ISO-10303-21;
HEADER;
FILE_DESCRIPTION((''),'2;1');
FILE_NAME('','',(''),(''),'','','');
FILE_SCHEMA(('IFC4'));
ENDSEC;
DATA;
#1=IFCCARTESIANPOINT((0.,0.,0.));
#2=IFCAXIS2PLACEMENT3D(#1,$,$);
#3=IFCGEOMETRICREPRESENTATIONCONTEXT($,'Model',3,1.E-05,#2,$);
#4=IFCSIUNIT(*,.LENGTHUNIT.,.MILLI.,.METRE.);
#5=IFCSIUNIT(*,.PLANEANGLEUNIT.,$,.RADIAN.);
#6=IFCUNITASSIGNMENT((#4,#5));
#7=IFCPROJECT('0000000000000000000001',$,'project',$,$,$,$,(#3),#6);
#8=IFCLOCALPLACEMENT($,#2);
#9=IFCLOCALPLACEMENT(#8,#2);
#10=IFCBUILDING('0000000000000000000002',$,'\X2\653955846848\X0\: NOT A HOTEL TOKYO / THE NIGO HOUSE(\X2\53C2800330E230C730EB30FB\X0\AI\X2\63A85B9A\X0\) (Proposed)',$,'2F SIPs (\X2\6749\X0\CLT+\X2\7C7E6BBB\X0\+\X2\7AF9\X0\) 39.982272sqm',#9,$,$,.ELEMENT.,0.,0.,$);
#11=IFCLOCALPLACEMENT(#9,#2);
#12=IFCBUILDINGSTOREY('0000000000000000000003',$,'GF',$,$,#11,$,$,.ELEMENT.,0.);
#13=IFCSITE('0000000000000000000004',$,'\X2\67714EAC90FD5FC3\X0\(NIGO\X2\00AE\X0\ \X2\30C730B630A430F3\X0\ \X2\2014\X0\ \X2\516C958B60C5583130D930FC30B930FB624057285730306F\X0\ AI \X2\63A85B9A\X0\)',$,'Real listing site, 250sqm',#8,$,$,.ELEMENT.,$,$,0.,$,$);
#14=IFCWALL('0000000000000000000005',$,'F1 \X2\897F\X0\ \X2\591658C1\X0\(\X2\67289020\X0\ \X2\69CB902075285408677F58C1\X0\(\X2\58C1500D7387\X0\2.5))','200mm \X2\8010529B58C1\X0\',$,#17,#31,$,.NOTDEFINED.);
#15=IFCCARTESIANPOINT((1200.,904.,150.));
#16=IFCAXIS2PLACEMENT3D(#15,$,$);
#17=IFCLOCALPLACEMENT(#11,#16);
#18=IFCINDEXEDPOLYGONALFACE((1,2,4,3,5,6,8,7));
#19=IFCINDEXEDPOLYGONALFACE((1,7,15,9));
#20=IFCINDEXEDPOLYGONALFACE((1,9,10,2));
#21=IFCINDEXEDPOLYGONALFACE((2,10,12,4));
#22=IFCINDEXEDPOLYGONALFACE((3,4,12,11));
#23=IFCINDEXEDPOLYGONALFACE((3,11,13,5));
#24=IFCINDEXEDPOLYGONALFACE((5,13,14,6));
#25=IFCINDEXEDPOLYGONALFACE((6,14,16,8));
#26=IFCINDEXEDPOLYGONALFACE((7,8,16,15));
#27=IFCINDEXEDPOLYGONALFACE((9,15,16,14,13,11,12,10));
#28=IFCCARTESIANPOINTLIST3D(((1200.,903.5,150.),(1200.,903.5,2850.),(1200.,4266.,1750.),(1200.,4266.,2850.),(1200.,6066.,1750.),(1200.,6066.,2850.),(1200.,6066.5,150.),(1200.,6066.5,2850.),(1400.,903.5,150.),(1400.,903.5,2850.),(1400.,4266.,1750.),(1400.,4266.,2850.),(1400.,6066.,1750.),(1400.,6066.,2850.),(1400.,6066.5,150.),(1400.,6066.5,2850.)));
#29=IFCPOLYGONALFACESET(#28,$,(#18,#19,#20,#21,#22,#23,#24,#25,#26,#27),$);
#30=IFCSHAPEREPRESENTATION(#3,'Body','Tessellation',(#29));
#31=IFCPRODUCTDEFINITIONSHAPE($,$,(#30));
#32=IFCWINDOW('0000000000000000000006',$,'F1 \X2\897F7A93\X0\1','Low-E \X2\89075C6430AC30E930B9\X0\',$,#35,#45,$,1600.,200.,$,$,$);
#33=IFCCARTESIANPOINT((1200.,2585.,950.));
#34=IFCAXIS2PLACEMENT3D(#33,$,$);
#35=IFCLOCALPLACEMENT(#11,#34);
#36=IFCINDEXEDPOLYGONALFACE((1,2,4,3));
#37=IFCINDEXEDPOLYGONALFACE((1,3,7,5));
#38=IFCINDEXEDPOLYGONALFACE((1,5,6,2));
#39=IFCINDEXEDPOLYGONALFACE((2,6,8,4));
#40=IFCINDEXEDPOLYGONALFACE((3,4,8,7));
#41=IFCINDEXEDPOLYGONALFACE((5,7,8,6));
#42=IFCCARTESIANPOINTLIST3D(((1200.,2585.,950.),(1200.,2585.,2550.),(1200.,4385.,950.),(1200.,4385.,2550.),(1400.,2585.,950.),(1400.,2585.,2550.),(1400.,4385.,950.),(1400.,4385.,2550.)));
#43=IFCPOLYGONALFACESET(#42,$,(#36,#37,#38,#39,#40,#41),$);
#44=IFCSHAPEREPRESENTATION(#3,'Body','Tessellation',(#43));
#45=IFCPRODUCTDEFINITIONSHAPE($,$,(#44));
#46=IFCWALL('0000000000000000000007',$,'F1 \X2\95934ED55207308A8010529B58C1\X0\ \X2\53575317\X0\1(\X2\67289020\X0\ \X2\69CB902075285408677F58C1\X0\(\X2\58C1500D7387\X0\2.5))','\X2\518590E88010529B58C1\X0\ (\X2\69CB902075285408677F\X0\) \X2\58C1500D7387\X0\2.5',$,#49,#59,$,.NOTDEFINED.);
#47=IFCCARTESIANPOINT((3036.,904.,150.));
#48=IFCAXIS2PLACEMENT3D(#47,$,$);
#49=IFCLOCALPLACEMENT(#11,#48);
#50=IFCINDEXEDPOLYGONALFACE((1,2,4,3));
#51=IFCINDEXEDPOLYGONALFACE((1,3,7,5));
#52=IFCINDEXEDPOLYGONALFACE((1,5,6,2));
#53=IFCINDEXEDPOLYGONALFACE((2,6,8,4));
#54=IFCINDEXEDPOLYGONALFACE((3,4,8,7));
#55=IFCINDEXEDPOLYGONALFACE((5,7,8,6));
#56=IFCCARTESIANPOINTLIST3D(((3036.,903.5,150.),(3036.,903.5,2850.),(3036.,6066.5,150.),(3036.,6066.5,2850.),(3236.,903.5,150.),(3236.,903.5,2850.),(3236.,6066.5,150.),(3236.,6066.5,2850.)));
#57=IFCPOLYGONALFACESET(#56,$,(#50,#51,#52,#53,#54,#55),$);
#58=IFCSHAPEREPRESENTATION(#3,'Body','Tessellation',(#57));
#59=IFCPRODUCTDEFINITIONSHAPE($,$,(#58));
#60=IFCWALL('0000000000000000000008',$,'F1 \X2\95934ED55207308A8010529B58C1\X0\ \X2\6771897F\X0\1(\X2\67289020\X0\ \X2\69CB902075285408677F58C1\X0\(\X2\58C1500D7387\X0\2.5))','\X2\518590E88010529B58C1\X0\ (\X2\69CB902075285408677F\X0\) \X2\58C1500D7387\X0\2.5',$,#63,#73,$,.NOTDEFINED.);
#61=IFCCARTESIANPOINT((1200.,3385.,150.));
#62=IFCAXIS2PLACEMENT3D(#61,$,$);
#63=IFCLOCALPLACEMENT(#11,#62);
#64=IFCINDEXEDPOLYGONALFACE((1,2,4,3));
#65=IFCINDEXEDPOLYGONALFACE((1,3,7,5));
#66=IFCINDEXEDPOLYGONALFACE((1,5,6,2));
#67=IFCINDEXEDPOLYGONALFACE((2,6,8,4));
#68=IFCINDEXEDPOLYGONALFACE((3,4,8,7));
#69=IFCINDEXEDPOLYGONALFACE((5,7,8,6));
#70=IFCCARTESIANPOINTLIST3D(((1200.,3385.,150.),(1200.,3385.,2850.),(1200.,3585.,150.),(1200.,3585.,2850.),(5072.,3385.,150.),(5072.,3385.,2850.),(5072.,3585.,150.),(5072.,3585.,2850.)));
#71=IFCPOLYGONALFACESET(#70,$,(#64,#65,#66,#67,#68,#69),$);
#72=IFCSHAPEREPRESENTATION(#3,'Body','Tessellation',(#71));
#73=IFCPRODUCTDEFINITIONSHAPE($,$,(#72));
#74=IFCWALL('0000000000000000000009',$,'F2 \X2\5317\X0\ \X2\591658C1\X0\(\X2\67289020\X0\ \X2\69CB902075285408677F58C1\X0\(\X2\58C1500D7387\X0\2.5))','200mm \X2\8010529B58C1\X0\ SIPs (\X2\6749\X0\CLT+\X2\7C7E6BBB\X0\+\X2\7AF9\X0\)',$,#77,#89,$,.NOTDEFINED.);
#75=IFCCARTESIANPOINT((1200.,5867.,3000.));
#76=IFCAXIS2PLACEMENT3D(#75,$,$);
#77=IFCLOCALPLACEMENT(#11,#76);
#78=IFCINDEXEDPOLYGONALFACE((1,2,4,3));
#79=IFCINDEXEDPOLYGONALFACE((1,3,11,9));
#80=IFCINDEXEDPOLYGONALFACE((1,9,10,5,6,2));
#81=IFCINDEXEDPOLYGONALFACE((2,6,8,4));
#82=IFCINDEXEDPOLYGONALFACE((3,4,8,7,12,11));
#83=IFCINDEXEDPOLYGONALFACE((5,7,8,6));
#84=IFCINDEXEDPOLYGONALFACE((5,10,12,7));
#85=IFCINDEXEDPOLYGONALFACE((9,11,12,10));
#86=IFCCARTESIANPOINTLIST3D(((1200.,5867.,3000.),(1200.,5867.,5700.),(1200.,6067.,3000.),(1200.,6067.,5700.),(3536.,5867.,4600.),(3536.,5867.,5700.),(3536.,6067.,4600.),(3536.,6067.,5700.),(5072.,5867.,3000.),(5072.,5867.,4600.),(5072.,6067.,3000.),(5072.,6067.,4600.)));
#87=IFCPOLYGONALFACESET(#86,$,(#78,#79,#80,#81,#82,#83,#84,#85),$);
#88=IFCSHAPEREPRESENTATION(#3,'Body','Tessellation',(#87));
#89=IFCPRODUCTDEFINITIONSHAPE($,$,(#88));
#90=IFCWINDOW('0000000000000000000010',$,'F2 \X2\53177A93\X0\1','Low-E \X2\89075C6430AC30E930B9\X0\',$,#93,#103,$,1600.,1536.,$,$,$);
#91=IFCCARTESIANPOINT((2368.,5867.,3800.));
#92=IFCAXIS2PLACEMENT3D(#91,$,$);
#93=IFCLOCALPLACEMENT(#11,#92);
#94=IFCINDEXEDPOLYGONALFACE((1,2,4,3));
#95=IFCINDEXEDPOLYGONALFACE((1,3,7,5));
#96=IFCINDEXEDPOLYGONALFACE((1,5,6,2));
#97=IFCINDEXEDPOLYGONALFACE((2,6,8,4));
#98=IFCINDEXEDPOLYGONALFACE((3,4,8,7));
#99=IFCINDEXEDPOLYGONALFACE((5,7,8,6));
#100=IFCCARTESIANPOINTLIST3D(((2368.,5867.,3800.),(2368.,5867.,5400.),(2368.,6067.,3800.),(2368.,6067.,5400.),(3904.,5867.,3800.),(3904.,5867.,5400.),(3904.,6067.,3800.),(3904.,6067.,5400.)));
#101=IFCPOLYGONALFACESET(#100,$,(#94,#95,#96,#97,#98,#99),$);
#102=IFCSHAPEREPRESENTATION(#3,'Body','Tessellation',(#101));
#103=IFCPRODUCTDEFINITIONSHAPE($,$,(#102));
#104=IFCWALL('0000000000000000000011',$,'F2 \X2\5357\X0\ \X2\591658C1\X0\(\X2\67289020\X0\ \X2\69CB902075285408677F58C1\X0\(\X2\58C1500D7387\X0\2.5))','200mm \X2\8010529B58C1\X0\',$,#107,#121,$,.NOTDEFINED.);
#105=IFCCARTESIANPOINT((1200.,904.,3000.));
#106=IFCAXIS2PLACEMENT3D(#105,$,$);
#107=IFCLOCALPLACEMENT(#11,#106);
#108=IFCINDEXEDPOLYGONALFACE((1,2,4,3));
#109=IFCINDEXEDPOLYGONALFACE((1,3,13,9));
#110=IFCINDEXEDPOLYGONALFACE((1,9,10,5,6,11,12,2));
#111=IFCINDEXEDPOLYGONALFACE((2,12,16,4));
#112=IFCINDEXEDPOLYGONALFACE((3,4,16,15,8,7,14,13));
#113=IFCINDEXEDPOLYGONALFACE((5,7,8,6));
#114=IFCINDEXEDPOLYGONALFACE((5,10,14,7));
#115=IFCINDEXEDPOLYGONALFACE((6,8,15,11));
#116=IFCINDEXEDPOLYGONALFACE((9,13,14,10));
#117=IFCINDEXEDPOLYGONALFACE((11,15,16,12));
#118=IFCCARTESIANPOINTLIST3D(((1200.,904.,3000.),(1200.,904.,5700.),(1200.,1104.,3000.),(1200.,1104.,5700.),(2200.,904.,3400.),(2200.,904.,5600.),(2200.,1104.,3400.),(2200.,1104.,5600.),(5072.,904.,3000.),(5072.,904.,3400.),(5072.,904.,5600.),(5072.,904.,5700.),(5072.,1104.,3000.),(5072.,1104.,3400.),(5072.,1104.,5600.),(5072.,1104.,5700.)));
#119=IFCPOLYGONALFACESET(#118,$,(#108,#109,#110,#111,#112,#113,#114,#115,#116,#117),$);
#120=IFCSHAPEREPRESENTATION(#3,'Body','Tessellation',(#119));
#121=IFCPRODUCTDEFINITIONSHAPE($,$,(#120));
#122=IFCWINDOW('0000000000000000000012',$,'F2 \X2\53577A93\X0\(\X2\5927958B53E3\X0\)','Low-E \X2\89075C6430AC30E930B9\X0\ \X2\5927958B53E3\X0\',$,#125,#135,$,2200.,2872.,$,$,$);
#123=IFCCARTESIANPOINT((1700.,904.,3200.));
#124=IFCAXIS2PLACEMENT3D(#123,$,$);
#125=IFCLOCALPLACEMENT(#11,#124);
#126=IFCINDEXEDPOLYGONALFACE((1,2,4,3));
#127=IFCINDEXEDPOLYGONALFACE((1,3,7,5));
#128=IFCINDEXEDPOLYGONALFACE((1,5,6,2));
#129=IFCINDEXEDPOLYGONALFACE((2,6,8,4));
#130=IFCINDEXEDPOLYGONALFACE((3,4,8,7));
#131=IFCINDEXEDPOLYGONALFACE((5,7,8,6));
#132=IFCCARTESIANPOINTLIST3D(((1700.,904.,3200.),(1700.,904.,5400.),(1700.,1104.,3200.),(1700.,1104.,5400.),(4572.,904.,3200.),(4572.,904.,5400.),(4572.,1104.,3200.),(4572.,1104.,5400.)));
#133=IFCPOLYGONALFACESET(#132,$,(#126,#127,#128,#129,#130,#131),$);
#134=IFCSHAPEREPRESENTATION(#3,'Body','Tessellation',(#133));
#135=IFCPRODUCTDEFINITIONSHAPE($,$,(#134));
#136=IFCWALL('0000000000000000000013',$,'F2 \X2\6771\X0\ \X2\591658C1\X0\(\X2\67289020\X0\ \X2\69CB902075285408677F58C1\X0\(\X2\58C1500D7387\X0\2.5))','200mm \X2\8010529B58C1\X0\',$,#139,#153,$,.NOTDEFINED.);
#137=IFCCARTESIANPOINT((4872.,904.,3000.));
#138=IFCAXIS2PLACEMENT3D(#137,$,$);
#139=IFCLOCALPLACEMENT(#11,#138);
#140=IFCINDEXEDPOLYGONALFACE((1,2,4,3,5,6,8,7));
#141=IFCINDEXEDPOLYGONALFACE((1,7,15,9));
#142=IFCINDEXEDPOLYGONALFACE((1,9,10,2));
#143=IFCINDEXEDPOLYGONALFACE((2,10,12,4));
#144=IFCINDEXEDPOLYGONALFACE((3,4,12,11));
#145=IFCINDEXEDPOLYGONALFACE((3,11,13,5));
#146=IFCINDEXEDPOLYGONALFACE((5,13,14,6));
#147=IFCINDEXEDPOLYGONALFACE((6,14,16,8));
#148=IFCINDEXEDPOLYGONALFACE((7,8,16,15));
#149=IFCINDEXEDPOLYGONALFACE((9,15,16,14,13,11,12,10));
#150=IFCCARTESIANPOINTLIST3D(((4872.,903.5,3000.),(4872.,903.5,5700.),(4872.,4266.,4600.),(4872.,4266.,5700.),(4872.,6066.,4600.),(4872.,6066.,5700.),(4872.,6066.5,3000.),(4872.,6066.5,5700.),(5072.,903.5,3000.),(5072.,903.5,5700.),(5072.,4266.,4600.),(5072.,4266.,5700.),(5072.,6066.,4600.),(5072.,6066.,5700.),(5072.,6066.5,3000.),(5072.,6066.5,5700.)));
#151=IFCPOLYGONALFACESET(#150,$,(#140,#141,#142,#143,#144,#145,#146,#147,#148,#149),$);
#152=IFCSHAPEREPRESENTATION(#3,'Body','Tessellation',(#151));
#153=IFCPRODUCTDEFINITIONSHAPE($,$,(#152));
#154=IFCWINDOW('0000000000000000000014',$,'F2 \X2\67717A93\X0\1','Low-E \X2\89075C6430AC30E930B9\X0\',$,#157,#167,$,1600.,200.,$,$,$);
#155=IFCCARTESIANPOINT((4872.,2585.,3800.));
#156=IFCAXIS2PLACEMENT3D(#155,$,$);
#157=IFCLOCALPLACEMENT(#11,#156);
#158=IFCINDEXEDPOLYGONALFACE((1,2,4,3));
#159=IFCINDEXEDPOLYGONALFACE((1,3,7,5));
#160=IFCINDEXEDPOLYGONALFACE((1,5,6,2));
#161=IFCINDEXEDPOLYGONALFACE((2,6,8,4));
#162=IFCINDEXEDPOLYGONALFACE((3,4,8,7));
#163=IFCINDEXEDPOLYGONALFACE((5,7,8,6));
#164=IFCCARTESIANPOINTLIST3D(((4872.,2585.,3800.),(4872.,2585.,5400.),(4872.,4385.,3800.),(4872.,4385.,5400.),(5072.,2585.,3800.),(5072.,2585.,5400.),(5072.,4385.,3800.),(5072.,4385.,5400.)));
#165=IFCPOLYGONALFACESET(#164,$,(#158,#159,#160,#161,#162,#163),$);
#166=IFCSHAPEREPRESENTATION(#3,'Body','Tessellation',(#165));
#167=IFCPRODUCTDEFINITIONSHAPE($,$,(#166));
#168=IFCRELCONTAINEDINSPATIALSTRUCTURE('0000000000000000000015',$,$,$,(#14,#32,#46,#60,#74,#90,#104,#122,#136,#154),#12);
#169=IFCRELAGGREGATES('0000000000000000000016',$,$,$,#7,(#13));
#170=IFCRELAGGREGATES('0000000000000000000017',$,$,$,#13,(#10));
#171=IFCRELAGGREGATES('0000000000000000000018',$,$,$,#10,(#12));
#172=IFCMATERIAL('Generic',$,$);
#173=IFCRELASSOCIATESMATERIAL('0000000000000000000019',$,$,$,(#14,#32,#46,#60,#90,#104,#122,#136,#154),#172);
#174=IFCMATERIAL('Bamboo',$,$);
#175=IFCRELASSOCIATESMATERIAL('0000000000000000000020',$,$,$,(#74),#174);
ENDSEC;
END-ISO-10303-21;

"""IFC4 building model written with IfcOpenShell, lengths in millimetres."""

from ifc_helpers import new_model, si_unit, frame, frame_2d, origin, place, context, project, spatial, rectangle, extrude, material, element, fill, save


model = new_model("IFC4")

# Units and contexts
model_context = context("Model", 3, precision=1e-05, world=origin())
ifc_project = project(units=[si_unit("LENGTHUNIT", "METRE", prefix="MILLI"), si_unit("PLANEANGLEUNIT", "RADIAN")], contexts=[model_context])

# Site, building, storey
site_placement = place(None, origin())
site = spatial("IfcSite", under=ifc_project, at=site_placement, Name="東京都心(NIGO® デザイン — 公開情報ベース・所在地は AI 推定)", ObjectType="Real listing site, 250sqm", CompositionType="ELEMENT", RefElevation=0.0)
building_placement = place(site_placement, origin())
building = spatial("IfcBuilding", under=site, at=building_placement, Name="改善案: NOT A HOTEL TOKYO / THE NIGO HOUSE(参考モデル・AI推定) (Proposed)", ObjectType="2F SIPs (杉CLT+籾殻+竹) 39.982272sqm", CompositionType="ELEMENT", ElevationOfRefHeight=0.0, ElevationOfTerrain=0.0)
storey_placement = place(building_placement, origin())
storey = spatial("IfcBuildingStorey", under=building, at=storey_placement, Name="GF", CompositionType="ELEMENT", Elevation=0.0)

# Shared definitions
ifc_material_1 = material(Name="Generic")

# Shared definitions
ifc_material_2 = material(Name="Bamboo")

# Wall, opening, window
wall_1_placement = place(storey_placement, frame((1200.0, 904.0, 150.0)))
wall_1 = element("IfcWall", 1, at=wall_1_placement, inside=storey, material=ifc_material_1, Name="F1 西 外壁(木造 構造用合板壁(壁倍率2.5))", Description="200mm 耐力壁", PredefinedType="NOTDEFINED", context=model_context, shape_type="SweptSolid", body=[
    extrude(rectangle(XDim=200.0, YDim=5163.0, at=frame_2d((100.0, 2581.0))), frame((1200.0, 904.0, 150.0)), (0.0, 0.0, 1.0), 2700.0),
])
opening_1_placement = place(storey_placement, frame((1200.0, 2585.0, 950.0)))
opening_1 = element("IfcOpeningElement", 2, at=opening_1_placement, cuts=wall_1, PredefinedType="NOTDEFINED", context=model_context, shape_type="SweptSolid", body=[
    extrude(rectangle(XDim=200.0, YDim=1800.0, at=frame_2d((100.0, 900.0))), frame((1200.0, 2585.0, 950.0)), (0.0, 0.0, 1.0), 1600.0),
])
window_1_placement = place(storey_placement, frame((1200.0, 2585.0, 950.0)))
window_1 = element("IfcWindow", 3, at=window_1_placement, inside=storey, material=ifc_material_1, Name="F1 西窓1", Description="Low-E 複層ガラス", OverallHeight=1600.0, OverallWidth=200.0, context=model_context, shape_type="SweptSolid", body=[
    extrude(rectangle(XDim=200.0, YDim=1800.0, at=frame_2d((100.0, 900.0))), frame((1200.0, 2585.0, 950.0)), (0.0, 0.0, 1.0), 1600.0),
])
fill(opening_1, window_1)

# Walls
wall_2_placement = place(storey_placement, frame((3036.0, 904.0, 150.0)))
element("IfcWall", 4, at=wall_2_placement, inside=storey, material=ifc_material_1, Name="F1 間仕切り耐力壁 南北1(木造 構造用合板壁(壁倍率2.5))", Description="内部耐力壁 (構造用合板) 壁倍率2.5", PredefinedType="NOTDEFINED", context=model_context, shape_type="SweptSolid", body=[
    extrude(rectangle(XDim=200.0, YDim=5163.0, at=frame_2d((100.0, 2581.0))), frame((3036.0, 904.0, 150.0)), (0.0, 0.0, 1.0), 2700.0),
])
wall_3_placement = place(storey_placement, frame((1200.0, 3385.0, 150.0)))
element("IfcWall", 5, at=wall_3_placement, inside=storey, material=ifc_material_1, Name="F1 間仕切り耐力壁 東西1(木造 構造用合板壁(壁倍率2.5))", Description="内部耐力壁 (構造用合板) 壁倍率2.5", PredefinedType="NOTDEFINED", context=model_context, shape_type="SweptSolid", body=[
    extrude(rectangle(XDim=3872.0, YDim=200.0, at=frame_2d((1936.0, 100.0))), frame((1200.0, 3385.0, 150.0)), (0.0, 0.0, 1.0), 2700.0),
])

# Walls, openings, windows
wall_4_placement = place(storey_placement, frame((1200.0, 5867.0, 3000.0)))
wall_4 = element("IfcWall", 6, at=wall_4_placement, inside=storey, material=ifc_material_2, Name="F2 北 外壁(木造 構造用合板壁(壁倍率2.5))", Description="200mm 耐力壁 SIPs (杉CLT+籾殻+竹)", PredefinedType="NOTDEFINED", context=model_context, shape_type="SweptSolid", body=[
    extrude(rectangle(XDim=3872.0, YDim=200.0, at=frame_2d((1936.0, 100.0))), frame((1200.0, 5867.0, 3000.0)), (0.0, 0.0, 1.0), 2700.0),
])
opening_2_placement = place(storey_placement, frame((2368.0, 5867.0, 3800.0)))
opening_2 = element("IfcOpeningElement", 7, at=opening_2_placement, cuts=wall_4, PredefinedType="NOTDEFINED", context=model_context, shape_type="SweptSolid", body=[
    extrude(rectangle(XDim=1536.0, YDim=200.0, at=frame_2d((768.0, 100.0))), frame((2368.0, 5867.0, 3800.0)), (0.0, 0.0, 1.0), 1600.0),
])
window_2_placement = place(storey_placement, frame((2368.0, 5867.0, 3800.0)))
window_2 = element("IfcWindow", 8, at=window_2_placement, inside=storey, material=ifc_material_1, Name="F2 北窓1", Description="Low-E 複層ガラス", OverallHeight=1600.0, OverallWidth=1536.0, context=model_context, shape_type="SweptSolid", body=[
    extrude(rectangle(XDim=1536.0, YDim=200.0, at=frame_2d((768.0, 100.0))), frame((2368.0, 5867.0, 3800.0)), (0.0, 0.0, 1.0), 1600.0),
])
fill(opening_2, window_2)
wall_5_placement = place(storey_placement, frame((1200.0, 904.0, 3000.0)))
wall_5 = element("IfcWall", 9, at=wall_5_placement, inside=storey, material=ifc_material_1, Name="F2 南 外壁(木造 構造用合板壁(壁倍率2.5))", Description="200mm 耐力壁", PredefinedType="NOTDEFINED", context=model_context, shape_type="SweptSolid", body=[
    extrude(rectangle(XDim=3872.0, YDim=200.0, at=frame_2d((1936.0, 100.0))), frame((1200.0, 904.0, 3000.0)), (0.0, 0.0, 1.0), 2700.0),
])
opening_3_placement = place(storey_placement, frame((1700.0, 904.0, 3200.0)))
opening_3 = element("IfcOpeningElement", 10, at=opening_3_placement, cuts=wall_5, PredefinedType="NOTDEFINED", context=model_context, shape_type="SweptSolid", body=[
    extrude(rectangle(XDim=2872.0, YDim=200.0, at=frame_2d((1436.0, 100.0))), frame((1700.0, 904.0, 3200.0)), (0.0, 0.0, 1.0), 2200.0),
])
window_3_placement = place(storey_placement, frame((1700.0, 904.0, 3200.0)))
window_3 = element("IfcWindow", 11, at=window_3_placement, inside=storey, material=ifc_material_1, Name="F2 南窓(大開口)", Description="Low-E 複層ガラス 大開口", OverallHeight=2200.0, OverallWidth=2872.0, context=model_context, shape_type="SweptSolid", body=[
    extrude(rectangle(XDim=2872.0, YDim=200.0, at=frame_2d((1436.0, 100.0))), frame((1700.0, 904.0, 3200.0)), (0.0, 0.0, 1.0), 2200.0),
])
fill(opening_3, window_3)
wall_6_placement = place(storey_placement, frame((4872.0, 904.0, 3000.0)))
wall_6 = element("IfcWall", 12, at=wall_6_placement, inside=storey, material=ifc_material_1, Name="F2 東 外壁(木造 構造用合板壁(壁倍率2.5))", Description="200mm 耐力壁", PredefinedType="NOTDEFINED", context=model_context, shape_type="SweptSolid", body=[
    extrude(rectangle(XDim=200.0, YDim=5163.0, at=frame_2d((100.0, 2581.0))), frame((4872.0, 904.0, 3000.0)), (0.0, 0.0, 1.0), 2700.0),
])
opening_4_placement = place(storey_placement, frame((4872.0, 2585.0, 3800.0)))
opening_4 = element("IfcOpeningElement", 13, at=opening_4_placement, cuts=wall_6, PredefinedType="NOTDEFINED", context=model_context, shape_type="SweptSolid", body=[
    extrude(rectangle(XDim=200.0, YDim=1800.0, at=frame_2d((100.0, 900.0))), frame((4872.0, 2585.0, 3800.0)), (0.0, 0.0, 1.0), 1600.0),
])
window_4_placement = place(storey_placement, frame((4872.0, 2585.0, 3800.0)))
window_4 = element("IfcWindow", 14, at=window_4_placement, inside=storey, material=ifc_material_1, Name="F2 東窓1", Description="Low-E 複層ガラス", OverallHeight=1600.0, OverallWidth=200.0, context=model_context, shape_type="SweptSolid", body=[
    extrude(rectangle(XDim=200.0, YDim=1800.0, at=frame_2d((100.0, 900.0))), frame((4872.0, 2585.0, 3800.0)), (0.0, 0.0, 1.0), 1600.0),
])
fill(opening_4, window_4)

save(model, "model.ifc")
